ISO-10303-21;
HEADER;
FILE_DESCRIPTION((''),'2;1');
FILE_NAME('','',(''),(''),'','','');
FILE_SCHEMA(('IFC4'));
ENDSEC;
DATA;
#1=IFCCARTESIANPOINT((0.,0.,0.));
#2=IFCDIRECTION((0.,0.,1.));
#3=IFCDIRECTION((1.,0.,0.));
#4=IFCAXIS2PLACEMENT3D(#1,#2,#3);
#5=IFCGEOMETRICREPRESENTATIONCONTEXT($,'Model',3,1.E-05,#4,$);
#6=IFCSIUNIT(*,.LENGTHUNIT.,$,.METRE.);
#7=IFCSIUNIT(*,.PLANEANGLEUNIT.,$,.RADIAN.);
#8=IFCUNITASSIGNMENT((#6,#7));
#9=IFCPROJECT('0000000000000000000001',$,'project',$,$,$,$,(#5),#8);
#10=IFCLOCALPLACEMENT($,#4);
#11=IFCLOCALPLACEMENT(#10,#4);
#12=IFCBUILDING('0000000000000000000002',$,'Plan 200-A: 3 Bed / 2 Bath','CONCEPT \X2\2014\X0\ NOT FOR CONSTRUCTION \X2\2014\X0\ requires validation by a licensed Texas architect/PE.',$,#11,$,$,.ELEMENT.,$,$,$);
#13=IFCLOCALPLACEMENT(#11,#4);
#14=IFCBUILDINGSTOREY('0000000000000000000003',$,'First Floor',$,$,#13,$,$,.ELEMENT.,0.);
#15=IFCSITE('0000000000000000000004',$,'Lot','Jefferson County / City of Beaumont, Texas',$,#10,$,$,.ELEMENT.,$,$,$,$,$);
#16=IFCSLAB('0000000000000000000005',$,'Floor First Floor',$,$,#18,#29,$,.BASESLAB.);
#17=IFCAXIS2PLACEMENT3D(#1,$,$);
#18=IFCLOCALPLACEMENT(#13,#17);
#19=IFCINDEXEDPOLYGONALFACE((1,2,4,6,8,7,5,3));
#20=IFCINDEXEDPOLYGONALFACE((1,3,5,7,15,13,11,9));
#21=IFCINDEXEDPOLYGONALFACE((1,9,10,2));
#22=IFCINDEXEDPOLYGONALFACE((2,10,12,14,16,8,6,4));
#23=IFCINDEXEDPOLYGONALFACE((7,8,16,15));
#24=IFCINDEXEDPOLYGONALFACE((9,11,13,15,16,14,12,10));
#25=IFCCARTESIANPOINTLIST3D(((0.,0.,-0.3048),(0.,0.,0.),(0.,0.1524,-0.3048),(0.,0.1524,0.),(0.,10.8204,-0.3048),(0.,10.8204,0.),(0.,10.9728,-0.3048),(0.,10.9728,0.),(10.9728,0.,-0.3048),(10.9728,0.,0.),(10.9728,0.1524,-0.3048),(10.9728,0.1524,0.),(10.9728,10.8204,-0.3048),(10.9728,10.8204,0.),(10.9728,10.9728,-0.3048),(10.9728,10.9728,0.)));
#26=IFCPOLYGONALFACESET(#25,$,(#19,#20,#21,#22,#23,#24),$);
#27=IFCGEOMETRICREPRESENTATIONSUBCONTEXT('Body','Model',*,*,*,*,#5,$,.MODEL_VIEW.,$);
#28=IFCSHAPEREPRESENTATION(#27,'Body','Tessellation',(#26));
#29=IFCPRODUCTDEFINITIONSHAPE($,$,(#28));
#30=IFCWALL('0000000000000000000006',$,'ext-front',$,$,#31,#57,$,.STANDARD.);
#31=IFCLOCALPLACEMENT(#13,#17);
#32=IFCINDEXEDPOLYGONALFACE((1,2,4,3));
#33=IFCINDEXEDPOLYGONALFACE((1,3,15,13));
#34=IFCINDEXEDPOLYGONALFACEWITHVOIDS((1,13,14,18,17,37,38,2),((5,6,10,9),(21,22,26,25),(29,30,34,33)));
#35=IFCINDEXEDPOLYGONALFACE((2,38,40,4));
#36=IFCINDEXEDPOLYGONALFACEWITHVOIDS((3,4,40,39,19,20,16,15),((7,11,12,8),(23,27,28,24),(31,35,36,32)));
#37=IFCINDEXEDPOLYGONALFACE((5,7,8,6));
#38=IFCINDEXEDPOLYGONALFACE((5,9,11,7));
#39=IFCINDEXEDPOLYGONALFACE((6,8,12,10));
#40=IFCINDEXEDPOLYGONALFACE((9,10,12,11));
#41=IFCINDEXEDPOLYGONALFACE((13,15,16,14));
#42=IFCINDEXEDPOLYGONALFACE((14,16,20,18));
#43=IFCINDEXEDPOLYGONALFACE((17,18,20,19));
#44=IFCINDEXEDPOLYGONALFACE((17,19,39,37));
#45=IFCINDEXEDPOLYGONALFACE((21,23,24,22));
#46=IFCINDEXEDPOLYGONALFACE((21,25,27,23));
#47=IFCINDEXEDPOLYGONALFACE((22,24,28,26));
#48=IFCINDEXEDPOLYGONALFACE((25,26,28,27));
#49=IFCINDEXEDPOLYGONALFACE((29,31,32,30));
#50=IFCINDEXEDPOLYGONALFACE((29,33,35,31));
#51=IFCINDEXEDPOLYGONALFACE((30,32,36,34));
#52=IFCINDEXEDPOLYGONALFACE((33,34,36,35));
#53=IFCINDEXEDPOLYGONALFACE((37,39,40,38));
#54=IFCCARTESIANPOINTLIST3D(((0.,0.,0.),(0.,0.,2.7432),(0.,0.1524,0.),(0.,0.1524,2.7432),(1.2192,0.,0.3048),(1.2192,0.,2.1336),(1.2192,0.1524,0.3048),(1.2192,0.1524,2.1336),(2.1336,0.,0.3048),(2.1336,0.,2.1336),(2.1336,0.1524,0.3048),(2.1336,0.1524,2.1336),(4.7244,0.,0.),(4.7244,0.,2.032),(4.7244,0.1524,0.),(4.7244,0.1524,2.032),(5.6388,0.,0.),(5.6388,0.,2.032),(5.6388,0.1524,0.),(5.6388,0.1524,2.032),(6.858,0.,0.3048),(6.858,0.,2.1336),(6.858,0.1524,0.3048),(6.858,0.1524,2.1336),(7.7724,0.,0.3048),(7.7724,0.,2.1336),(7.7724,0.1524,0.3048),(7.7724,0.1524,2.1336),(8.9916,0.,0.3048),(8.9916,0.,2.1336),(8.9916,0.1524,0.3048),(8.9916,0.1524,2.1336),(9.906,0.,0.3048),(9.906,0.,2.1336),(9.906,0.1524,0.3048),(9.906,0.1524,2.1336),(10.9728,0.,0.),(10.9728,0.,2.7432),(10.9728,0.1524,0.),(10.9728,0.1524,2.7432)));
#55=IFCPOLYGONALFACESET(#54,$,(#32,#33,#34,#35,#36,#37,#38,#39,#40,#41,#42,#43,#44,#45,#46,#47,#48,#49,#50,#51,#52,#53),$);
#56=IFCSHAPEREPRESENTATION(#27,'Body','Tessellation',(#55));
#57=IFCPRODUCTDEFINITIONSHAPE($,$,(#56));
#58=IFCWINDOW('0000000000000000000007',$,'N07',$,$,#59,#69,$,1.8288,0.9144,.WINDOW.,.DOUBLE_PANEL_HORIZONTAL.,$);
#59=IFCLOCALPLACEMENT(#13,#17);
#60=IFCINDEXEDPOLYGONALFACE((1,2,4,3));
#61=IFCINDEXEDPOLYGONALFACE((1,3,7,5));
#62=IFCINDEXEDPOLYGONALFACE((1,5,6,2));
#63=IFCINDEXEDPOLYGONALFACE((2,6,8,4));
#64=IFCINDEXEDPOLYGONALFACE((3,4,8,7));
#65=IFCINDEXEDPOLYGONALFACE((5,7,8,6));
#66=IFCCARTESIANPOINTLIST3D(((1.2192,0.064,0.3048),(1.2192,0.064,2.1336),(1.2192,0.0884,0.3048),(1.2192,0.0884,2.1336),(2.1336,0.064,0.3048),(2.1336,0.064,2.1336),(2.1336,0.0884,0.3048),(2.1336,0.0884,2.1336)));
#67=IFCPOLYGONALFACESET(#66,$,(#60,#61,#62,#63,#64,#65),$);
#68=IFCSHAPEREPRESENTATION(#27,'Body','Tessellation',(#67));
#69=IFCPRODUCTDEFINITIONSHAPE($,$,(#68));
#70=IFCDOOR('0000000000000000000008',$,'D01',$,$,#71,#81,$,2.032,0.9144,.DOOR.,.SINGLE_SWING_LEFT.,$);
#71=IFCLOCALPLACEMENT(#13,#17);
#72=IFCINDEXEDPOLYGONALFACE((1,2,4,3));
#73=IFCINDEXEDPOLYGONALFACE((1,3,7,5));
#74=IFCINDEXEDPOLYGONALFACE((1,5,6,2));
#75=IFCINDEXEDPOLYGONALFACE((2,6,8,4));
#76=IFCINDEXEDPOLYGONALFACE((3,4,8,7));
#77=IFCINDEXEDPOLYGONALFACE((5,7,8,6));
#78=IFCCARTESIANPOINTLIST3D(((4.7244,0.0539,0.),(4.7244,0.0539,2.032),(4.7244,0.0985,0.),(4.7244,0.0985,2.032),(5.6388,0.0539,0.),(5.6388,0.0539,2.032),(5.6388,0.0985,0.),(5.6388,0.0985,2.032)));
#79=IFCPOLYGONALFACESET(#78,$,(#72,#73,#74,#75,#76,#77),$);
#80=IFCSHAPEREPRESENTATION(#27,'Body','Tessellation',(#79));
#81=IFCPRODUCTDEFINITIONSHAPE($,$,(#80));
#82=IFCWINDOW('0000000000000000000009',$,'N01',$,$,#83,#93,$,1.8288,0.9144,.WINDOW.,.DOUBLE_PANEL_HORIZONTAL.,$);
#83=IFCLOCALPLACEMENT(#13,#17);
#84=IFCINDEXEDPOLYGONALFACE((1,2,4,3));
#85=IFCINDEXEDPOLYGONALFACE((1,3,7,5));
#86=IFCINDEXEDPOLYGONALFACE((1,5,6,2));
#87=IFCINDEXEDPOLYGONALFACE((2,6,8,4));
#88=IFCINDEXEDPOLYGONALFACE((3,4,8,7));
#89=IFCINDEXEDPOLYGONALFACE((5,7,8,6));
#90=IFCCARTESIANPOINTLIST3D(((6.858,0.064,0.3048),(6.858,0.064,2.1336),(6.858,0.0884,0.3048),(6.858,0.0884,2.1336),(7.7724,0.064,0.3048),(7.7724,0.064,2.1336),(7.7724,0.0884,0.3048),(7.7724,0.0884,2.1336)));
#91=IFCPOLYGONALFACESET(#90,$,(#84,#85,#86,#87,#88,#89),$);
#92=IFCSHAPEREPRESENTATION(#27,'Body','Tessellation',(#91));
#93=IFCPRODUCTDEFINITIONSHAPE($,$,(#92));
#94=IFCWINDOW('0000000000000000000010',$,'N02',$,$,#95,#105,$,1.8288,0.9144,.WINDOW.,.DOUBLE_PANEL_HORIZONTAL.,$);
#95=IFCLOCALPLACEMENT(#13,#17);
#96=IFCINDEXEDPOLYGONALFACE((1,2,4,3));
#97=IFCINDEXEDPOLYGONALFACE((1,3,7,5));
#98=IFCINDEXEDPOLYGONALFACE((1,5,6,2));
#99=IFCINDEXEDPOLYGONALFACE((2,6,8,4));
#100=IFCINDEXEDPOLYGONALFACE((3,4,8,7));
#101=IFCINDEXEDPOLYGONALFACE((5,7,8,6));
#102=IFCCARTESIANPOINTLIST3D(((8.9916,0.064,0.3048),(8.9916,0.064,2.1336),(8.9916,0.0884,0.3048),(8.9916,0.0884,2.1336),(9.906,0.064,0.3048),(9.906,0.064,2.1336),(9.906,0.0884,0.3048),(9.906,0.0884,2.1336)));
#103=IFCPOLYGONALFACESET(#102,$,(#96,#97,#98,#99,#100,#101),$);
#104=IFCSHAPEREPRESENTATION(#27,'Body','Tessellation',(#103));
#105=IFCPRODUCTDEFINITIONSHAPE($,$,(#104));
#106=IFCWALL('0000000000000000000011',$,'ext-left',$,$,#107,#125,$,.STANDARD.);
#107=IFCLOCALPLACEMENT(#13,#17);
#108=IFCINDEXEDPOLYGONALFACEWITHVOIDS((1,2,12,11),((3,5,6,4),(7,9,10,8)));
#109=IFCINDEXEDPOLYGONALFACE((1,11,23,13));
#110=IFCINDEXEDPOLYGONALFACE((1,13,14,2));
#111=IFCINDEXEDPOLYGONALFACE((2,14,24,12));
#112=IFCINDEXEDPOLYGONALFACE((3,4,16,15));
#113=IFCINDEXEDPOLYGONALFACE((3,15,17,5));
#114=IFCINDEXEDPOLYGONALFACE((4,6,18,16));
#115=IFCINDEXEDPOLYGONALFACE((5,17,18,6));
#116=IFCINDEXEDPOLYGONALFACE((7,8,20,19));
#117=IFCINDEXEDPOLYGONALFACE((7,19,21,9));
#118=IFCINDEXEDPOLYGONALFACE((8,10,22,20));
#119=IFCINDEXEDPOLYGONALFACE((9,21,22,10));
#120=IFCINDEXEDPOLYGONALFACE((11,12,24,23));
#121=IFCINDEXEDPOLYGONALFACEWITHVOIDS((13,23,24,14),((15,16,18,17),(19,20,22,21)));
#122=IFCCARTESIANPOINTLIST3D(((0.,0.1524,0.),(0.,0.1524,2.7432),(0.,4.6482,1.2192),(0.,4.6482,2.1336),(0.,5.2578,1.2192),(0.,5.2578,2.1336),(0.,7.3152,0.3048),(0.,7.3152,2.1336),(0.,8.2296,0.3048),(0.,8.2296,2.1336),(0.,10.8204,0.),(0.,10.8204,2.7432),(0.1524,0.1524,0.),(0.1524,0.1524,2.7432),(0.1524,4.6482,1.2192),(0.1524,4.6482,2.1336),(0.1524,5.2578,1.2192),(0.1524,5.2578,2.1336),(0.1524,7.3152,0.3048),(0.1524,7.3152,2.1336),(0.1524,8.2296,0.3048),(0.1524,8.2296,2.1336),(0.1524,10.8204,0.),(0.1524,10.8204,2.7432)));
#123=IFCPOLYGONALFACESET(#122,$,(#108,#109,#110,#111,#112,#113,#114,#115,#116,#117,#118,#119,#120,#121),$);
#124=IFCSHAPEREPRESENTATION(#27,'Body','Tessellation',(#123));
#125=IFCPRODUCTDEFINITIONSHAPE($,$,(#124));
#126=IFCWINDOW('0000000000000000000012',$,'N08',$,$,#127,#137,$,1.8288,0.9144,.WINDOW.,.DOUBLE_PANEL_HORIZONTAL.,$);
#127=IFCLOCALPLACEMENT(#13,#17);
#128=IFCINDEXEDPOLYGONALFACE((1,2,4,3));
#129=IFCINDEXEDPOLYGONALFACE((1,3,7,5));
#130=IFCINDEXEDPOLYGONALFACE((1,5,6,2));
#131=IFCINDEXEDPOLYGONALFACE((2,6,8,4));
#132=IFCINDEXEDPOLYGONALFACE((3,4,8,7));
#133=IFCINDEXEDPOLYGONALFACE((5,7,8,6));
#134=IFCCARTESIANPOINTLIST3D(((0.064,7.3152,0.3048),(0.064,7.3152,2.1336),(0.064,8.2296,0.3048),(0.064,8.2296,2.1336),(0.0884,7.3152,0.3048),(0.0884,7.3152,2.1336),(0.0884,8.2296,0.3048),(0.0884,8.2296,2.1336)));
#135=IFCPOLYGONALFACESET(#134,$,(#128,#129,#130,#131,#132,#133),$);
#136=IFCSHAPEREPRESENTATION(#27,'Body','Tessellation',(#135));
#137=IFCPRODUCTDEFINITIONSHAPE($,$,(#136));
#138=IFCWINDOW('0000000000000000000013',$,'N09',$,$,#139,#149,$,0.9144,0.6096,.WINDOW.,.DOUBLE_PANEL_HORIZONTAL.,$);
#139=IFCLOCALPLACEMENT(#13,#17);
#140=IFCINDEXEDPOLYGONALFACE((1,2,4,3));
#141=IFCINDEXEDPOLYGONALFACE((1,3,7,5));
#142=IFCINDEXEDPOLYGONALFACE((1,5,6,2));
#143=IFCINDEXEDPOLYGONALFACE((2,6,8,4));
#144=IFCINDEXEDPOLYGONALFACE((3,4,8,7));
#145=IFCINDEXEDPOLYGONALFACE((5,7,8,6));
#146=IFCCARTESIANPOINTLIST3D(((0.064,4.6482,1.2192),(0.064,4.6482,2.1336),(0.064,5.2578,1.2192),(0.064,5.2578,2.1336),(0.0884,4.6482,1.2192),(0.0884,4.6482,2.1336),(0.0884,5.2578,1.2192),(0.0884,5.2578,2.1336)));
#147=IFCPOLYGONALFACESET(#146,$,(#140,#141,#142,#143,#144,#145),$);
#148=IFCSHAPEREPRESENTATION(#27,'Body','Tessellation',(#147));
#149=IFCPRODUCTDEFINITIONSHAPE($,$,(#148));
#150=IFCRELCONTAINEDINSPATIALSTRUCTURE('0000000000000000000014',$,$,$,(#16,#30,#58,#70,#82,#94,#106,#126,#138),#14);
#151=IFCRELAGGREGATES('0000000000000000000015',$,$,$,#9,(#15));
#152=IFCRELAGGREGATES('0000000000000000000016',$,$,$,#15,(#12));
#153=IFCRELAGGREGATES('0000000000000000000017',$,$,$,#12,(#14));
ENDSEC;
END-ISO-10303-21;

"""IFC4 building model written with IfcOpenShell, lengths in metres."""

from ifc_helpers import new_model, si_unit, frame, frame_2d, origin_with_axes, place, context, subcontext, project, spatial, polyline, rectangle, outline, extrude, element, fill, save


model = new_model("IFC4")

# Units and contexts
model_context = context("Model", 3, precision=1e-05, world=origin_with_axes())
body_context = subcontext(model_context, "Body", "Model", "MODEL_VIEW")
ifc_project = project(units=[si_unit("LENGTHUNIT", "METRE"), si_unit("PLANEANGLEUNIT", "RADIAN")], contexts=[model_context])

# Site, building, storey
site_placement = place(None, origin_with_axes())
site = spatial("IfcSite", under=ifc_project, at=site_placement, Name="Lot", Description="Jefferson County / City of Beaumont, Texas", CompositionType="ELEMENT")
building_placement = place(site_placement, origin_with_axes())
building = spatial("IfcBuilding", under=site, at=building_placement, Name="Plan 200-A: 3 Bed / 2 Bath", Description="CONCEPT — NOT FOR CONSTRUCTION — requires validation by a licensed Texas architect/PE.", CompositionType="ELEMENT")
storey_placement = place(building_placement, origin_with_axes())
storey = spatial("IfcBuildingStorey", under=building, at=storey_placement, Name="First Floor", CompositionType="ELEMENT", Elevation=0.0)

# Slab
slab_placement = place(storey_placement, frame((0.0, 0.0, -0.3048), z_axis=(0.0, 0.0, 1.0), x_axis=(1.0, 0.0, 0.0)))
element("IfcSlab", 1, at=slab_placement, inside=storey, Name="Floor First Floor", PredefinedType="BASESLAB", context=body_context, shape_type="SweptSolid", body=[
    extrude(outline(polyline([(10.9728, 0.1524), (10.9728, 0.0), (0.0, 0.0), (0.0, 0.1524), (0.0, 10.8204), (0.0, 10.9728), (10.9728, 10.9728), (10.9728, 10.8204), (10.9728, 0.1524)])), origin_with_axes(), (0.0, 0.0, 1.0), 0.3048),
])

# Wall, openings, windows, door
wall_1_placement = place(storey_placement, frame((0.0, 0.0762, 0.0), z_axis=(0.0, 0.0, 1.0), x_axis=(1.0, 0.0, 0.0)))
wall_1 = element("IfcWall", 2, at=wall_1_placement, inside=storey, Name="ext-front", PredefinedType="STANDARD", context=body_context, shape_type="SweptSolid", body=[
    extrude(rectangle(XDim=10.9728, YDim=0.1524, at=frame_2d((5.4864, 0.0), x_axis=(1.0, 0.0))), origin_with_axes(), (0.0, 0.0, 1.0), 2.7432),
])
opening_1_placement = place(wall_1_placement, frame((1.2192, 0.0, 0.3048), z_axis=(0.0, 0.0, 1.0), x_axis=(1.0, 0.0, 0.0)))
opening_1 = element("IfcOpeningElement", 3, at=opening_1_placement, cuts=wall_1, PredefinedType="OPENING", context=body_context, shape_type="SweptSolid", body=[
    extrude(rectangle(XDim=0.9144, YDim=0.1829, at=frame_2d((0.4572, 0.0), x_axis=(1.0, 0.0))), origin_with_axes(), (0.0, 0.0, 1.0), 1.8288),
])
opening_2_placement = place(wall_1_placement, frame((4.7244, 0.0, 0.0), z_axis=(0.0, 0.0, 1.0), x_axis=(1.0, 0.0, 0.0)))
opening_2 = element("IfcOpeningElement", 4, at=opening_2_placement, cuts=wall_1, PredefinedType="OPENING", context=body_context, shape_type="SweptSolid", body=[
    extrude(rectangle(XDim=0.9144, YDim=0.1829, at=frame_2d((0.4572, 0.0), x_axis=(1.0, 0.0))), origin_with_axes(), (0.0, 0.0, 1.0), 2.032),
])
opening_3_placement = place(wall_1_placement, frame((6.858, 0.0, 0.3048), z_axis=(0.0, 0.0, 1.0), x_axis=(1.0, 0.0, 0.0)))
opening_3 = element("IfcOpeningElement", 5, at=opening_3_placement, cuts=wall_1, PredefinedType="OPENING", context=body_context, shape_type="SweptSolid", body=[
    extrude(rectangle(XDim=0.9144, YDim=0.1829, at=frame_2d((0.4572, 0.0), x_axis=(1.0, 0.0))), origin_with_axes(), (0.0, 0.0, 1.0), 1.8288),
])
opening_4_placement = place(wall_1_placement, frame((8.9916, 0.0, 0.3048), z_axis=(0.0, 0.0, 1.0), x_axis=(1.0, 0.0, 0.0)))
opening_4 = element("IfcOpeningElement", 6, at=opening_4_placement, cuts=wall_1, PredefinedType="OPENING", context=body_context, shape_type="SweptSolid", body=[
    extrude(rectangle(XDim=0.9144, YDim=0.1829, at=frame_2d((0.4572, 0.0), x_axis=(1.0, 0.0))), origin_with_axes(), (0.0, 0.0, 1.0), 1.8288),
])
window_1_placement = place(opening_1_placement, origin_with_axes())
window_1 = element("IfcWindow", 7, at=window_1_placement, inside=storey, Name="N07", OverallHeight=1.8288, OverallWidth=0.9144, PartitioningType="DOUBLE_PANEL_HORIZONTAL", PredefinedType="WINDOW", context=body_context, shape_type="SweptSolid", body=[
    extrude(rectangle(XDim=0.9144, YDim=0.0244, at=frame_2d((0.4572, 0.0), x_axis=(1.0, 0.0))), origin_with_axes(), (0.0, 0.0, 1.0), 1.8288),
])
fill(opening_1, window_1)
door_1_placement = place(opening_2_placement, origin_with_axes())
door_1 = element("IfcDoor", 8, at=door_1_placement, inside=storey, Name="D01", OperationType="SINGLE_SWING_LEFT", OverallHeight=2.032, OverallWidth=0.9144, PredefinedType="DOOR", context=body_context, shape_type="SweptSolid", body=[
    extrude(rectangle(XDim=0.9144, YDim=0.0445, at=frame_2d((0.4572, 0.0), x_axis=(1.0, 0.0))), origin_with_axes(), (0.0, 0.0, 1.0), 2.032),
])
fill(opening_2, door_1)
window_2_placement = place(opening_3_placement, origin_with_axes())
window_2 = element("IfcWindow", 9, at=window_2_placement, inside=storey, Name="N01", OverallHeight=1.8288, OverallWidth=0.9144, PartitioningType="DOUBLE_PANEL_HORIZONTAL", PredefinedType="WINDOW", context=body_context, shape_type="SweptSolid", body=[
    extrude(rectangle(XDim=0.9144, YDim=0.0244, at=frame_2d((0.4572, 0.0), x_axis=(1.0, 0.0))), origin_with_axes(), (0.0, 0.0, 1.0), 1.8288),
])
fill(opening_3, window_2)
window_3_placement = place(opening_4_placement, origin_with_axes())
window_3 = element("IfcWindow", 10, at=window_3_placement, inside=storey, Name="N02", OverallHeight=1.8288, OverallWidth=0.9144, PartitioningType="DOUBLE_PANEL_HORIZONTAL", PredefinedType="WINDOW", context=body_context, shape_type="SweptSolid", body=[
    extrude(rectangle(XDim=0.9144, YDim=0.0244, at=frame_2d((0.4572, 0.0), x_axis=(1.0, 0.0))), origin_with_axes(), (0.0, 0.0, 1.0), 1.8288),
])
fill(opening_4, window_3)

# Wall, openings, windows
wall_2_placement = place(storey_placement, frame((0.0762, 10.8204, 0.0), z_axis=(0.0, 0.0, 1.0), x_axis=(0.0, -1.0, 0.0)))
wall_2 = element("IfcWall", 11, at=wall_2_placement, inside=storey, Name="ext-left", PredefinedType="STANDARD", context=body_context, shape_type="SweptSolid", body=[
    extrude(rectangle(XDim=10.668, YDim=0.1524, at=frame_2d((5.334, 0.0), x_axis=(1.0, 0.0))), origin_with_axes(), (0.0, 0.0, 1.0), 2.7432),
])
opening_5_placement = place(wall_2_placement, frame((2.5908, 0.0, 0.3048), z_axis=(0.0, 0.0, 1.0), x_axis=(1.0, 0.0, 0.0)))
opening_5 = element("IfcOpeningElement", 12, at=opening_5_placement, cuts=wall_2, PredefinedType="OPENING", context=body_context, shape_type="SweptSolid", body=[
    extrude(rectangle(XDim=0.9144, YDim=0.1829, at=frame_2d((0.4572, 0.0), x_axis=(1.0, 0.0))), origin_with_axes(), (0.0, 0.0, 1.0), 1.8288),
])
opening_6_placement = place(wall_2_placement, frame((5.5626, 0.0, 1.2192), z_axis=(0.0, 0.0, 1.0), x_axis=(1.0, 0.0, 0.0)))
opening_6 = element("IfcOpeningElement", 13, at=opening_6_placement, cuts=wall_2, PredefinedType="OPENING", context=body_context, shape_type="SweptSolid", body=[
    extrude(rectangle(XDim=0.6096, YDim=0.1829, at=frame_2d((0.3048, 0.0), x_axis=(1.0, 0.0))), origin_with_axes(), (0.0, 0.0, 1.0), 0.9144),
])
window_4_placement = place(opening_5_placement, origin_with_axes())
window_4 = element("IfcWindow", 14, at=window_4_placement, inside=storey, Name="N08", OverallHeight=1.8288, OverallWidth=0.9144, PartitioningType="DOUBLE_PANEL_HORIZONTAL", PredefinedType="WINDOW", context=body_context, shape_type="SweptSolid", body=[
    extrude(rectangle(XDim=0.9144, YDim=0.0244, at=frame_2d((0.4572, 0.0), x_axis=(1.0, 0.0))), origin_with_axes(), (0.0, 0.0, 1.0), 1.8288),
])
fill(opening_5, window_4)
window_5_placement = place(opening_6_placement, origin_with_axes())
window_5 = element("IfcWindow", 15, at=window_5_placement, inside=storey, Name="N09", OverallHeight=0.9144, OverallWidth=0.6096, PartitioningType="DOUBLE_PANEL_HORIZONTAL", PredefinedType="WINDOW", context=body_context, shape_type="SweptSolid", body=[
    extrude(rectangle(XDim=0.6096, YDim=0.0244, at=frame_2d((0.3048, 0.0), x_axis=(1.0, 0.0))), origin_with_axes(), (0.0, 0.0, 1.0), 0.9144),
])
fill(opening_6, window_5)

save(model, "model.ifc")
